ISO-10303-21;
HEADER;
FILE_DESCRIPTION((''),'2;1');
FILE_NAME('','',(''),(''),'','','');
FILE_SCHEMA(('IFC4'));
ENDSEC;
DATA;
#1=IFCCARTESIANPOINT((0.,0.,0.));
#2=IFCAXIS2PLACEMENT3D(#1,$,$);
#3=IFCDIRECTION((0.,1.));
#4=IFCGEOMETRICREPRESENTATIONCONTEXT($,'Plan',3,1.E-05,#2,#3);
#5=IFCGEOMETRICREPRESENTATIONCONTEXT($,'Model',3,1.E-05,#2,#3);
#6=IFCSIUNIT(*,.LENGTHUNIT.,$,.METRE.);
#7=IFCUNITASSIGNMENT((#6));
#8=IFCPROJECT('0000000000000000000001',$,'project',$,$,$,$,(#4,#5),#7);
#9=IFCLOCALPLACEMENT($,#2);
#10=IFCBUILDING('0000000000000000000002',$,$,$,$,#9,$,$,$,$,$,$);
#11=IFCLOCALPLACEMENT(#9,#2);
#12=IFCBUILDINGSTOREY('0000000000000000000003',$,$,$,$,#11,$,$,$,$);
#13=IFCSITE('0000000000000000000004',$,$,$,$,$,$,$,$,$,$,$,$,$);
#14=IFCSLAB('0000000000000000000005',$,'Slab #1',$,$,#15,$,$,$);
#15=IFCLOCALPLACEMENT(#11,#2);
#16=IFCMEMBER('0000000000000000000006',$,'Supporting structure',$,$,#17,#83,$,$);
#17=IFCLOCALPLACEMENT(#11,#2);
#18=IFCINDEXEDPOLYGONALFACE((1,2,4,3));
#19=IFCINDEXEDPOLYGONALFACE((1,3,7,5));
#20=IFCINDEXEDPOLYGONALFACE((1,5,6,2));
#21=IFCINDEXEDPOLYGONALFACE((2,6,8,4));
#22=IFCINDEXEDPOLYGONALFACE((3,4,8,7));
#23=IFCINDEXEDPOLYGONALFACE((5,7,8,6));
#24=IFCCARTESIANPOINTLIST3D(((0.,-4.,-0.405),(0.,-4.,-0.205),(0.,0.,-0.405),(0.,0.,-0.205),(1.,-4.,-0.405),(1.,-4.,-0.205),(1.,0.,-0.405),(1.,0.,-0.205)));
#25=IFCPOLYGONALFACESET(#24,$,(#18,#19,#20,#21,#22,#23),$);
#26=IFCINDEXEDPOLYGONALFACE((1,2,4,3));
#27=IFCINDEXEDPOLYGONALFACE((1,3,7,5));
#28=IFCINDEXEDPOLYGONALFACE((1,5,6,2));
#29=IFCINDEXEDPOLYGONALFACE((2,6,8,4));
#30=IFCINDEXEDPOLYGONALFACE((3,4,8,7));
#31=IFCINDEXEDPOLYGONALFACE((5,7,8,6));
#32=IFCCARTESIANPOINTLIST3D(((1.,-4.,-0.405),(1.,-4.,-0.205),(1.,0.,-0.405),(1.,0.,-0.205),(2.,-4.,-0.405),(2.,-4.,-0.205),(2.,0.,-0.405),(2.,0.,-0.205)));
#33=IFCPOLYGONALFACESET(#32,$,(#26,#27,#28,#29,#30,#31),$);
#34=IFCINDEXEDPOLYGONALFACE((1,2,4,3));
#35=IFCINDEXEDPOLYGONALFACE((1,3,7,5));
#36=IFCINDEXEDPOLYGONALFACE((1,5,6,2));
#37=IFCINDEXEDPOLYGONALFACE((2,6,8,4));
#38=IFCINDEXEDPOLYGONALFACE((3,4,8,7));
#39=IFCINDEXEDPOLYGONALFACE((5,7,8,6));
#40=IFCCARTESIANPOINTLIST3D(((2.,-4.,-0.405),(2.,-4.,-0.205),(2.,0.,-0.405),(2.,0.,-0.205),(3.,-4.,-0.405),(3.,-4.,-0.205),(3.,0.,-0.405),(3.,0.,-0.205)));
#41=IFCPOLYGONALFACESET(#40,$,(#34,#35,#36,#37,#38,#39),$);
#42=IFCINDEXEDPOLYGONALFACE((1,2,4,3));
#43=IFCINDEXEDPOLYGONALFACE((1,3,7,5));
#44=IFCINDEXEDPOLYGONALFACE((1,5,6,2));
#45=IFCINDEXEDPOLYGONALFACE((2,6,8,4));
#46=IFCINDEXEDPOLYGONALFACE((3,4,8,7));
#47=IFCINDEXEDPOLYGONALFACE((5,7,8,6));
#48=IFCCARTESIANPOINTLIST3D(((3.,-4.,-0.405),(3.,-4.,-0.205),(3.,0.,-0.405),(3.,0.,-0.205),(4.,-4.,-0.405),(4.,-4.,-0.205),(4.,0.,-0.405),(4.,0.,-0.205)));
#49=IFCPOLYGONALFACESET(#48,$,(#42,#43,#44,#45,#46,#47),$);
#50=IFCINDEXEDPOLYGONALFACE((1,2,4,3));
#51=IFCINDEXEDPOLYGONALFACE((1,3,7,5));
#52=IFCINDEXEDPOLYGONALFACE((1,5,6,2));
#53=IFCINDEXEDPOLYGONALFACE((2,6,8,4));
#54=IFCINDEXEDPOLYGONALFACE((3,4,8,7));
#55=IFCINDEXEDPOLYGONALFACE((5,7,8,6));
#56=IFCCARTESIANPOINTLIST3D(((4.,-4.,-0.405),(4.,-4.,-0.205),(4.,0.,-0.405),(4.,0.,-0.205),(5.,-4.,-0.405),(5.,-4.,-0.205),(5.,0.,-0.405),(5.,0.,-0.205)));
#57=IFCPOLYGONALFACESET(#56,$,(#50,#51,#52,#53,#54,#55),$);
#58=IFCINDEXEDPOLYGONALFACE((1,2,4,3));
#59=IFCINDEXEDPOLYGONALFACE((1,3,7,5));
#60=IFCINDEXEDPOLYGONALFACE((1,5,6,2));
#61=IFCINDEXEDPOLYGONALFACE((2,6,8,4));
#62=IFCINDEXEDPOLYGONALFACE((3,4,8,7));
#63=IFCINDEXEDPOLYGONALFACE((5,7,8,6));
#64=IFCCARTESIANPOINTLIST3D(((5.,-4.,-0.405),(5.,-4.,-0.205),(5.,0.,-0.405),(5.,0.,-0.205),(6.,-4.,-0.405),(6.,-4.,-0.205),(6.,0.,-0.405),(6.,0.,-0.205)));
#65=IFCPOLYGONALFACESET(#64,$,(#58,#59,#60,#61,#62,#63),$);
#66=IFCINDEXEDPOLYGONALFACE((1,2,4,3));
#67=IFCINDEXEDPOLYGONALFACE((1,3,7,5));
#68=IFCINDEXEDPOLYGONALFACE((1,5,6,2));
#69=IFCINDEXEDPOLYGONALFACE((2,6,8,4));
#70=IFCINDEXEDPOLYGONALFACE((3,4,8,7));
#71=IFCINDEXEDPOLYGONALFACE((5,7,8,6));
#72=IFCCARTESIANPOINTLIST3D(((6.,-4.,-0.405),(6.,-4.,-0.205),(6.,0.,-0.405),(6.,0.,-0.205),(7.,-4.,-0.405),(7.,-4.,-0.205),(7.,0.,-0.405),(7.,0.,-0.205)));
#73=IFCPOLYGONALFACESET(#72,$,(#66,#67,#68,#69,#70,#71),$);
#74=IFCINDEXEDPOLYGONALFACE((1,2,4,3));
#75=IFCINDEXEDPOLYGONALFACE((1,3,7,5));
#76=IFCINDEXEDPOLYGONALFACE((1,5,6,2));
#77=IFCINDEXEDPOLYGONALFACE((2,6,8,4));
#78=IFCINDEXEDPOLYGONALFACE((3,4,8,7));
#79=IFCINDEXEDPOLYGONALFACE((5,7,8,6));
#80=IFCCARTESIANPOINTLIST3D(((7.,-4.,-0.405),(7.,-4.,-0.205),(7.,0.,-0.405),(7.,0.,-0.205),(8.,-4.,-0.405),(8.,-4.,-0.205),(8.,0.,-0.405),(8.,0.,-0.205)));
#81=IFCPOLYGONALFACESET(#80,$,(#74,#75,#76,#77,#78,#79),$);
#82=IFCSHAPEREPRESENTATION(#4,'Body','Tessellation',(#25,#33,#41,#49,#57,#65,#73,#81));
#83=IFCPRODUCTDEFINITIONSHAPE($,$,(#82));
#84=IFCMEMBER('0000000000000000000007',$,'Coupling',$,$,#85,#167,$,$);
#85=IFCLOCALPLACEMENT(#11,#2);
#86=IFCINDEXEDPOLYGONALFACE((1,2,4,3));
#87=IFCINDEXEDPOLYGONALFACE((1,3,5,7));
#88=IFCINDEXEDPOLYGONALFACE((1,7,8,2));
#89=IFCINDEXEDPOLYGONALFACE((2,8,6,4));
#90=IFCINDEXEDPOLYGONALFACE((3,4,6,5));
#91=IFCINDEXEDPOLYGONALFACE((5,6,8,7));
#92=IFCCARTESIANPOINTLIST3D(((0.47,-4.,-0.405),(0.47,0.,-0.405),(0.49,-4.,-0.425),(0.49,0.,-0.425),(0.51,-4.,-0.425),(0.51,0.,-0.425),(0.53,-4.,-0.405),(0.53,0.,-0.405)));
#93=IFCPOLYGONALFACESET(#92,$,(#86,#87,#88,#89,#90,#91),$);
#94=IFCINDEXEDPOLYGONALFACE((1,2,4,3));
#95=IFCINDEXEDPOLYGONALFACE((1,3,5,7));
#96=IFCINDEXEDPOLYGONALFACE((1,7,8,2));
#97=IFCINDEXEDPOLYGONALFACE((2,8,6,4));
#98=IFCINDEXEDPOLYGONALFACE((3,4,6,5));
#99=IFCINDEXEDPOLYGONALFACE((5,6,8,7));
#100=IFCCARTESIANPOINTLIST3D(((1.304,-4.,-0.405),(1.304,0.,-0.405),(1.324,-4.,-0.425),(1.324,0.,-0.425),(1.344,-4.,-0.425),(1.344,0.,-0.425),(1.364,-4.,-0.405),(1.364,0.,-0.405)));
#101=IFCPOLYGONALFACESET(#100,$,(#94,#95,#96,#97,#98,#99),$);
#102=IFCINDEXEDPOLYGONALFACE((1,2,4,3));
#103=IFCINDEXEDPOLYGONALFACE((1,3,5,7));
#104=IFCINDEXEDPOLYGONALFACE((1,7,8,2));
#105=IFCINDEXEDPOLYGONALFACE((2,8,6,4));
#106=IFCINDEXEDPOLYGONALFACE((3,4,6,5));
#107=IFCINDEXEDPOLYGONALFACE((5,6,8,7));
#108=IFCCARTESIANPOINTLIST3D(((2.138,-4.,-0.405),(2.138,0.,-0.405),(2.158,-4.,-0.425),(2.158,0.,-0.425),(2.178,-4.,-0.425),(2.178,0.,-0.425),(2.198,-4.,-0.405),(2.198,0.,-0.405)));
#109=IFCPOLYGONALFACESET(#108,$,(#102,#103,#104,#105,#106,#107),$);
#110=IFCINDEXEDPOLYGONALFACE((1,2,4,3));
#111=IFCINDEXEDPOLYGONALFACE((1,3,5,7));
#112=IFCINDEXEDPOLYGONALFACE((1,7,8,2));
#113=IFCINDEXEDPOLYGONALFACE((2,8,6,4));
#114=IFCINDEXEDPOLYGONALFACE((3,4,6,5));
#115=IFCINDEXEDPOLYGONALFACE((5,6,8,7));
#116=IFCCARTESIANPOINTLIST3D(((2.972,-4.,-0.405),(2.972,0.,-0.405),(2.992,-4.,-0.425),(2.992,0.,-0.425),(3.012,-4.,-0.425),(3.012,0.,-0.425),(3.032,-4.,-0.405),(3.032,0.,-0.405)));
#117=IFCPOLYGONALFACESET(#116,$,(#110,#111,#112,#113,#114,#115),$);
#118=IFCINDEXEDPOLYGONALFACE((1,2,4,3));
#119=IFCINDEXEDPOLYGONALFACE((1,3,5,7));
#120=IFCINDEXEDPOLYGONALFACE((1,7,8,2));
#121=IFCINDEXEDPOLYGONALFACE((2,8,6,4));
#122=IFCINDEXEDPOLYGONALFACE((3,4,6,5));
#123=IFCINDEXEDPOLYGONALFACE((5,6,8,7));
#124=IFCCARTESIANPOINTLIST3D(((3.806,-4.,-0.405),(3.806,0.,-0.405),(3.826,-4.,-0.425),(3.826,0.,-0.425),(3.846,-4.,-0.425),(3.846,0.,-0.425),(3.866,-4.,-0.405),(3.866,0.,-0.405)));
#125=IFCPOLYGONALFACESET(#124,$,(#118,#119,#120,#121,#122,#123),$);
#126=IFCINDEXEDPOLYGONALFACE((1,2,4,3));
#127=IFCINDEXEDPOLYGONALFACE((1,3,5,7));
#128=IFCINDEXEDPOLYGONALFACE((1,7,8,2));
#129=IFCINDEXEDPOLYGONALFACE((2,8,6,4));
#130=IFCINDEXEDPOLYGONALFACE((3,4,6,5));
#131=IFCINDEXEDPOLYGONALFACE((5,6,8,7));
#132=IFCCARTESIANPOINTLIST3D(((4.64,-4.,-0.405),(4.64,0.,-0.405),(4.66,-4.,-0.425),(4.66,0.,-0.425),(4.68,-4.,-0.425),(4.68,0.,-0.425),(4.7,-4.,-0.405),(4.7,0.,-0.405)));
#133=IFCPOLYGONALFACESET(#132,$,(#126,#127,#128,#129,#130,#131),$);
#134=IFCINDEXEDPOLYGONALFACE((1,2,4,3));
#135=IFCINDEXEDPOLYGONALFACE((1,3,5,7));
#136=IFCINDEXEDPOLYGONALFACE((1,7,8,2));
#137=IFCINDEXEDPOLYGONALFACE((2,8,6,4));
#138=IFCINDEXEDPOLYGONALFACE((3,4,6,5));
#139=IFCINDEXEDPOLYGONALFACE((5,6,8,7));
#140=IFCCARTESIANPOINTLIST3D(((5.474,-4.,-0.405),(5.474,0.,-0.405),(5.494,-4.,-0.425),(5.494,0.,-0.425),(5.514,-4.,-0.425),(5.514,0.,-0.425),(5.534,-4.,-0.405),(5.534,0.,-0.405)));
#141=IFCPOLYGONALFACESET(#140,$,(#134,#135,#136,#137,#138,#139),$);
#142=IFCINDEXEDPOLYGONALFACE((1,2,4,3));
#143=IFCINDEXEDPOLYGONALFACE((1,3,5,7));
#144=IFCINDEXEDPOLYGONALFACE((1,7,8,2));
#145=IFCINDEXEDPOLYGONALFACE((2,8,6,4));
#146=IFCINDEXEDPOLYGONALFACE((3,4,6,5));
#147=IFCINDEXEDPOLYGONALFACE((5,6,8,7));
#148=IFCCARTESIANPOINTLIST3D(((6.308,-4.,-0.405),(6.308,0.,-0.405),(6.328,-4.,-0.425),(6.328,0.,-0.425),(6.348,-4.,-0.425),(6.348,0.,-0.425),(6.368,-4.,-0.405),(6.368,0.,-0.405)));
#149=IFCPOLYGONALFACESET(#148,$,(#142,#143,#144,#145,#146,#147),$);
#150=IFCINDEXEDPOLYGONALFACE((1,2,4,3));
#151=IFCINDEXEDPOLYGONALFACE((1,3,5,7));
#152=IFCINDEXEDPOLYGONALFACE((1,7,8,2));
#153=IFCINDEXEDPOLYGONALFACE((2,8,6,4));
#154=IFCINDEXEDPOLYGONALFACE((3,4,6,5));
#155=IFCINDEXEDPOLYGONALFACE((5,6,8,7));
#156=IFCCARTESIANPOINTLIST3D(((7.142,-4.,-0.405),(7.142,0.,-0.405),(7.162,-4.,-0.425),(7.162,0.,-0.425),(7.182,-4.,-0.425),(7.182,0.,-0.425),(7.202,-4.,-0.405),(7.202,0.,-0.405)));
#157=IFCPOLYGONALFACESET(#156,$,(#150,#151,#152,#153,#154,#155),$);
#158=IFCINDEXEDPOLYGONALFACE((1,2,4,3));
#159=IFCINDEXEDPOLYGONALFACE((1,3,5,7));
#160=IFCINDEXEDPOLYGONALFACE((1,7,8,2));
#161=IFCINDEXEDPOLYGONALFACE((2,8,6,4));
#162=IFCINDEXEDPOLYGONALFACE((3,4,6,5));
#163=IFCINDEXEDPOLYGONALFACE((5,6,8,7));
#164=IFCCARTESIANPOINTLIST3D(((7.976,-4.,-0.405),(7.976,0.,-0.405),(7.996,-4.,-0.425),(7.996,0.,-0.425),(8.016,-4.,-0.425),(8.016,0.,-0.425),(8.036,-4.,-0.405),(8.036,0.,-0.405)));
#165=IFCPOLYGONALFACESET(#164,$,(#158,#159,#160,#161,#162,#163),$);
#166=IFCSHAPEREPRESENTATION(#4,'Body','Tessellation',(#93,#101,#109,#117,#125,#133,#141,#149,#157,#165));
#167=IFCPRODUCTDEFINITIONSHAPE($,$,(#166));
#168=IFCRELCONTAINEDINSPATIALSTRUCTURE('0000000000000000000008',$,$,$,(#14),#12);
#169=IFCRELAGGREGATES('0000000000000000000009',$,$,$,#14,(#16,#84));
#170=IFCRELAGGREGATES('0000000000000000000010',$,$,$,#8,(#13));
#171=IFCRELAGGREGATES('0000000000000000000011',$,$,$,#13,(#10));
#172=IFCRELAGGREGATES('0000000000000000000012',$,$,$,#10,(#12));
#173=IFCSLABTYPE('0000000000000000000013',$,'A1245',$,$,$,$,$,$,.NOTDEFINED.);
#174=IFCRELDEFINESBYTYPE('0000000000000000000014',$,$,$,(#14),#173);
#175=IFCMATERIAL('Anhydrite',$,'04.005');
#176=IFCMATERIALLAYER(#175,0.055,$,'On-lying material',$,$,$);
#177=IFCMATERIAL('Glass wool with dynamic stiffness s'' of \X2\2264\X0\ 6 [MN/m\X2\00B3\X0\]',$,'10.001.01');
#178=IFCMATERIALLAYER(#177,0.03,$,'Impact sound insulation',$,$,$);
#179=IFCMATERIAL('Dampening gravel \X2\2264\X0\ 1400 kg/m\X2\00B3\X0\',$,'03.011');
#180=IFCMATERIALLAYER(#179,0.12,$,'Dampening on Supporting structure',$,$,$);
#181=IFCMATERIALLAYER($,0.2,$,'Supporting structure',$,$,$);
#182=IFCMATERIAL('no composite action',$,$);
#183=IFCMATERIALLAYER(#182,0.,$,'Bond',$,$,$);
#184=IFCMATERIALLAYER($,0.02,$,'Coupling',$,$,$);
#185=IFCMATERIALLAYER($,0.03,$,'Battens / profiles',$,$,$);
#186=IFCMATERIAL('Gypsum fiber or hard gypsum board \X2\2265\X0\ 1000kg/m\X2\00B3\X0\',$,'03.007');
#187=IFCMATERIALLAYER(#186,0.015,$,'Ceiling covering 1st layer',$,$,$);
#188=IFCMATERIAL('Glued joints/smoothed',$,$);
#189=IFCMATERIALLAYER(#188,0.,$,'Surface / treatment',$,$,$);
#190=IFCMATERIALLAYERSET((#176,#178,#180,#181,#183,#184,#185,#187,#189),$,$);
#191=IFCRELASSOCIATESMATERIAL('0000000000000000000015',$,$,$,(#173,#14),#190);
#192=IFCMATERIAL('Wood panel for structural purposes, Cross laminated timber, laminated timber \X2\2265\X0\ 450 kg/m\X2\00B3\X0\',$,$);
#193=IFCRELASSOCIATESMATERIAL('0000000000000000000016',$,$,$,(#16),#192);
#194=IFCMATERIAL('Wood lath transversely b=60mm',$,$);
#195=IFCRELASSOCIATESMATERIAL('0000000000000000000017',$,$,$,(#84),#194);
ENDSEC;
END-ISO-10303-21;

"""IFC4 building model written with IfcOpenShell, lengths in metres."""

from ifc_helpers import new_model, si_unit, direction, frame, frame_2d, origin, place, context, project, spatial, polyline, rectangle, outline, extrude, material, layer, layer_set, type_object, element, aggregate, save


model = new_model("IFC4")

# Units and contexts
plan_context = context("Plan", 3, precision=1e-05, world=origin(), true_north=direction((0.0, 1.0)))
model_context = context("Model", 3, precision=1e-05, world=origin(), true_north=direction((0.0, 1.0)))
ifc_project = project(units=[si_unit("LENGTHUNIT", "METRE")], contexts=[plan_context, model_context])

# Site, building, storey
site = spatial("IfcSite", under=ifc_project)
building_placement = place(None, origin())
building = spatial("IfcBuilding", under=site, at=building_placement)
storey_placement = place(building_placement, origin())
storey = spatial("IfcBuildingStorey", under=building, at=storey_placement)

# Slab, members
ifc_material_1 = material(Name="Anhydrite", Category="04.005")
ifc_layer_1 = layer(ifc_material_1, 0.055, Name="On-lying material")
ifc_material_2 = material(Name="Glass wool with dynamic stiffness s' of ≤ 6 [MN/m³]", Category="10.001.01")
ifc_layer_2 = layer(ifc_material_2, 0.03, Name="Impact sound insulation")
ifc_material_3 = material(Name="Dampening gravel ≤ 1400 kg/m³", Category="03.011")
ifc_layer_3 = layer(ifc_material_3, 0.12, Name="Dampening on Supporting structure")
ifc_layer_4 = layer(None, 0.2, Name="Supporting structure")
ifc_material_4 = material(Name="no composite action")
ifc_layer_5 = layer(ifc_material_4, 0.0, Name="Bond")
ifc_layer_6 = layer(None, 0.02, Name="Coupling")
ifc_layer_7 = layer(None, 0.03, Name="Battens / profiles")
ifc_material_5 = material(Name="Gypsum fiber or hard gypsum board ≥ 1000kg/m³", Category="03.007")
ifc_layer_8 = layer(ifc_material_5, 0.015, Name="Ceiling covering 1st layer")
ifc_material_6 = material(Name="Glued joints/smoothed")
ifc_layer_9 = layer(ifc_material_6, 0.0, Name="Surface / treatment")
ifc_layer_set = layer_set([ifc_layer_1, ifc_layer_2, ifc_layer_3, ifc_layer_4, ifc_layer_5, ifc_layer_6, ifc_layer_7, ifc_layer_8, ifc_layer_9])
slab_type = type_object("IfcSlabType", Name="A1245", PredefinedType="NOTDEFINED", material=ifc_layer_set)
slab_placement = place(None, frame((0.0, 0.0, 0.0), z_axis=(0.0, 0.0, -1.0), x_axis=(1.0, 0.0, 0.0)))
slab = element("IfcSlab", 1, at=slab_placement, inside=storey, type_object=slab_type, material=ifc_layer_set, Name="Slab #1")
ifc_material_7 = material(Name="Wood panel for structural purposes, Cross laminated timber, laminated timber ≥ 450 kg/m³")
member_1_placement = place(slab_placement, origin())
member_1 = element("IfcMember", 2, at=member_1_placement, material=ifc_material_7, Name="Supporting structure", context=plan_context, shape_type="SweptSolid", body=[
    extrude(rectangle(XDim=1.0, YDim=0.2, at=frame_2d((0.5, 0.1), x_axis=(1.0, 0.0))), frame((0.0, 4.0, 0.205), z_axis=(0.0, -1.0, 0.0), x_axis=(1.0, 0.0, 0.0)), (0.0, 0.0, 1.0), 4.0),
    extrude(rectangle(XDim=1.0, YDim=0.2, at=frame_2d((0.5, 0.1), x_axis=(1.0, 0.0))), frame((1.0, 4.0, 0.205), z_axis=(0.0, -1.0, 0.0), x_axis=(1.0, 0.0, 0.0)), (0.0, 0.0, 1.0), 4.0),
    extrude(rectangle(XDim=1.0, YDim=0.2, at=frame_2d((0.5, 0.1), x_axis=(1.0, 0.0))), frame((2.0, 4.0, 0.205), z_axis=(0.0, -1.0, 0.0), x_axis=(1.0, 0.0, 0.0)), (0.0, 0.0, 1.0), 4.0),
    extrude(rectangle(XDim=1.0, YDim=0.2, at=frame_2d((0.5, 0.1), x_axis=(1.0, 0.0))), frame((3.0, 4.0, 0.205), z_axis=(0.0, -1.0, 0.0), x_axis=(1.0, 0.0, 0.0)), (0.0, 0.0, 1.0), 4.0),
    extrude(rectangle(XDim=1.0, YDim=0.2, at=frame_2d((0.5, 0.1), x_axis=(1.0, 0.0))), frame((4.0, 4.0, 0.205), z_axis=(0.0, -1.0, 0.0), x_axis=(1.0, 0.0, 0.0)), (0.0, 0.0, 1.0), 4.0),
    extrude(rectangle(XDim=1.0, YDim=0.2, at=frame_2d((0.5, 0.1), x_axis=(1.0, 0.0))), frame((5.0, 4.0, 0.205), z_axis=(0.0, -1.0, 0.0), x_axis=(1.0, 0.0, 0.0)), (0.0, 0.0, 1.0), 4.0),
    extrude(rectangle(XDim=1.0, YDim=0.2, at=frame_2d((0.5, 0.1), x_axis=(1.0, 0.0))), frame((6.0, 4.0, 0.205), z_axis=(0.0, -1.0, 0.0), x_axis=(1.0, 0.0, 0.0)), (0.0, 0.0, 1.0), 4.0),
    extrude(rectangle(XDim=1.0, YDim=0.2, at=frame_2d((0.5, 0.1), x_axis=(1.0, 0.0))), frame((7.0, 4.0, 0.205), z_axis=(0.0, -1.0, 0.0), x_axis=(1.0, 0.0, 0.0)), (0.0, 0.0, 1.0), 4.0),
])
ifc_material_8 = material(Name="Wood lath transversely b=60mm")
member_2_placement = place(slab_placement, origin())
member_2 = element("IfcMember", 3, at=member_2_placement, material=ifc_material_8, Name="Coupling", context=plan_context, shape_type="SweptSolid", body=[
    extrude(outline(polyline([(0.0, 0.0), (0.06, 0.0), (0.04, 0.02), (0.02, 0.02), (0.0, 0.0)])), frame((0.47, 4.0, 0.405), z_axis=(0.0, -1.0, 0.0), x_axis=(1.0, 0.0, 0.0)), (0.0, 0.0, 1.0), 4.0),
    extrude(outline(polyline([(0.0, 0.0), (0.06, 0.0), (0.04, 0.02), (0.02, 0.02), (0.0, 0.0)])), frame((1.304, 4.0, 0.405), z_axis=(0.0, -1.0, 0.0), x_axis=(1.0, 0.0, 0.0)), (0.0, 0.0, 1.0), 4.0),
    extrude(outline(polyline([(0.0, 0.0), (0.06, 0.0), (0.04, 0.02), (0.02, 0.02), (0.0, 0.0)])), frame((2.138, 4.0, 0.405), z_axis=(0.0, -1.0, 0.0), x_axis=(1.0, 0.0, 0.0)), (0.0, 0.0, 1.0), 4.0),
    extrude(outline(polyline([(0.0, 0.0), (0.06, 0.0), (0.04, 0.02), (0.02, 0.02), (0.0, 0.0)])), frame((2.972, 4.0, 0.405), z_axis=(0.0, -1.0, 0.0), x_axis=(1.0, 0.0, 0.0)), (0.0, 0.0, 1.0), 4.0),
    extrude(outline(polyline([(0.0, 0.0), (0.06, 0.0), (0.04, 0.02), (0.02, 0.02), (0.0, 0.0)])), frame((3.806, 4.0, 0.405), z_axis=(0.0, -1.0, 0.0), x_axis=(1.0, 0.0, 0.0)), (0.0, 0.0, 1.0), 4.0),
    extrude(outline(polyline([(0.0, 0.0), (0.06, 0.0), (0.04, 0.02), (0.02, 0.02), (0.0, 0.0)])), frame((4.64, 4.0, 0.405), z_axis=(0.0, -1.0, 0.0), x_axis=(1.0, 0.0, 0.0)), (0.0, 0.0, 1.0), 4.0),
    extrude(outline(polyline([(0.0, 0.0), (0.06, 0.0), (0.04, 0.02), (0.02, 0.02), (0.0, 0.0)])), frame((5.474, 4.0, 0.405), z_axis=(0.0, -1.0, 0.0), x_axis=(1.0, 0.0, 0.0)), (0.0, 0.0, 1.0), 4.0),
    extrude(outline(polyline([(0.0, 0.0), (0.06, 0.0), (0.04, 0.02), (0.02, 0.02), (0.0, 0.0)])), frame((6.308, 4.0, 0.405), z_axis=(0.0, -1.0, 0.0), x_axis=(1.0, 0.0, 0.0)), (0.0, 0.0, 1.0), 4.0),
    extrude(outline(polyline([(0.0, 0.0), (0.06, 0.0), (0.04, 0.02), (0.02, 0.02), (0.0, 0.0)])), frame((7.142, 4.0, 0.405), z_axis=(0.0, -1.0, 0.0), x_axis=(1.0, 0.0, 0.0)), (0.0, 0.0, 1.0), 4.0),
    extrude(outline(polyline([(0.0, 0.0), (0.06, 0.0), (0.04, 0.02), (0.02, 0.02), (0.0, 0.0)])), frame((7.976, 4.0, 0.405), z_axis=(0.0, -1.0, 0.0), x_axis=(1.0, 0.0, 0.0)), (0.0, 0.0, 1.0), 4.0),
])
aggregate(slab, [member_1, member_2])

save(model, "model.ifc")
